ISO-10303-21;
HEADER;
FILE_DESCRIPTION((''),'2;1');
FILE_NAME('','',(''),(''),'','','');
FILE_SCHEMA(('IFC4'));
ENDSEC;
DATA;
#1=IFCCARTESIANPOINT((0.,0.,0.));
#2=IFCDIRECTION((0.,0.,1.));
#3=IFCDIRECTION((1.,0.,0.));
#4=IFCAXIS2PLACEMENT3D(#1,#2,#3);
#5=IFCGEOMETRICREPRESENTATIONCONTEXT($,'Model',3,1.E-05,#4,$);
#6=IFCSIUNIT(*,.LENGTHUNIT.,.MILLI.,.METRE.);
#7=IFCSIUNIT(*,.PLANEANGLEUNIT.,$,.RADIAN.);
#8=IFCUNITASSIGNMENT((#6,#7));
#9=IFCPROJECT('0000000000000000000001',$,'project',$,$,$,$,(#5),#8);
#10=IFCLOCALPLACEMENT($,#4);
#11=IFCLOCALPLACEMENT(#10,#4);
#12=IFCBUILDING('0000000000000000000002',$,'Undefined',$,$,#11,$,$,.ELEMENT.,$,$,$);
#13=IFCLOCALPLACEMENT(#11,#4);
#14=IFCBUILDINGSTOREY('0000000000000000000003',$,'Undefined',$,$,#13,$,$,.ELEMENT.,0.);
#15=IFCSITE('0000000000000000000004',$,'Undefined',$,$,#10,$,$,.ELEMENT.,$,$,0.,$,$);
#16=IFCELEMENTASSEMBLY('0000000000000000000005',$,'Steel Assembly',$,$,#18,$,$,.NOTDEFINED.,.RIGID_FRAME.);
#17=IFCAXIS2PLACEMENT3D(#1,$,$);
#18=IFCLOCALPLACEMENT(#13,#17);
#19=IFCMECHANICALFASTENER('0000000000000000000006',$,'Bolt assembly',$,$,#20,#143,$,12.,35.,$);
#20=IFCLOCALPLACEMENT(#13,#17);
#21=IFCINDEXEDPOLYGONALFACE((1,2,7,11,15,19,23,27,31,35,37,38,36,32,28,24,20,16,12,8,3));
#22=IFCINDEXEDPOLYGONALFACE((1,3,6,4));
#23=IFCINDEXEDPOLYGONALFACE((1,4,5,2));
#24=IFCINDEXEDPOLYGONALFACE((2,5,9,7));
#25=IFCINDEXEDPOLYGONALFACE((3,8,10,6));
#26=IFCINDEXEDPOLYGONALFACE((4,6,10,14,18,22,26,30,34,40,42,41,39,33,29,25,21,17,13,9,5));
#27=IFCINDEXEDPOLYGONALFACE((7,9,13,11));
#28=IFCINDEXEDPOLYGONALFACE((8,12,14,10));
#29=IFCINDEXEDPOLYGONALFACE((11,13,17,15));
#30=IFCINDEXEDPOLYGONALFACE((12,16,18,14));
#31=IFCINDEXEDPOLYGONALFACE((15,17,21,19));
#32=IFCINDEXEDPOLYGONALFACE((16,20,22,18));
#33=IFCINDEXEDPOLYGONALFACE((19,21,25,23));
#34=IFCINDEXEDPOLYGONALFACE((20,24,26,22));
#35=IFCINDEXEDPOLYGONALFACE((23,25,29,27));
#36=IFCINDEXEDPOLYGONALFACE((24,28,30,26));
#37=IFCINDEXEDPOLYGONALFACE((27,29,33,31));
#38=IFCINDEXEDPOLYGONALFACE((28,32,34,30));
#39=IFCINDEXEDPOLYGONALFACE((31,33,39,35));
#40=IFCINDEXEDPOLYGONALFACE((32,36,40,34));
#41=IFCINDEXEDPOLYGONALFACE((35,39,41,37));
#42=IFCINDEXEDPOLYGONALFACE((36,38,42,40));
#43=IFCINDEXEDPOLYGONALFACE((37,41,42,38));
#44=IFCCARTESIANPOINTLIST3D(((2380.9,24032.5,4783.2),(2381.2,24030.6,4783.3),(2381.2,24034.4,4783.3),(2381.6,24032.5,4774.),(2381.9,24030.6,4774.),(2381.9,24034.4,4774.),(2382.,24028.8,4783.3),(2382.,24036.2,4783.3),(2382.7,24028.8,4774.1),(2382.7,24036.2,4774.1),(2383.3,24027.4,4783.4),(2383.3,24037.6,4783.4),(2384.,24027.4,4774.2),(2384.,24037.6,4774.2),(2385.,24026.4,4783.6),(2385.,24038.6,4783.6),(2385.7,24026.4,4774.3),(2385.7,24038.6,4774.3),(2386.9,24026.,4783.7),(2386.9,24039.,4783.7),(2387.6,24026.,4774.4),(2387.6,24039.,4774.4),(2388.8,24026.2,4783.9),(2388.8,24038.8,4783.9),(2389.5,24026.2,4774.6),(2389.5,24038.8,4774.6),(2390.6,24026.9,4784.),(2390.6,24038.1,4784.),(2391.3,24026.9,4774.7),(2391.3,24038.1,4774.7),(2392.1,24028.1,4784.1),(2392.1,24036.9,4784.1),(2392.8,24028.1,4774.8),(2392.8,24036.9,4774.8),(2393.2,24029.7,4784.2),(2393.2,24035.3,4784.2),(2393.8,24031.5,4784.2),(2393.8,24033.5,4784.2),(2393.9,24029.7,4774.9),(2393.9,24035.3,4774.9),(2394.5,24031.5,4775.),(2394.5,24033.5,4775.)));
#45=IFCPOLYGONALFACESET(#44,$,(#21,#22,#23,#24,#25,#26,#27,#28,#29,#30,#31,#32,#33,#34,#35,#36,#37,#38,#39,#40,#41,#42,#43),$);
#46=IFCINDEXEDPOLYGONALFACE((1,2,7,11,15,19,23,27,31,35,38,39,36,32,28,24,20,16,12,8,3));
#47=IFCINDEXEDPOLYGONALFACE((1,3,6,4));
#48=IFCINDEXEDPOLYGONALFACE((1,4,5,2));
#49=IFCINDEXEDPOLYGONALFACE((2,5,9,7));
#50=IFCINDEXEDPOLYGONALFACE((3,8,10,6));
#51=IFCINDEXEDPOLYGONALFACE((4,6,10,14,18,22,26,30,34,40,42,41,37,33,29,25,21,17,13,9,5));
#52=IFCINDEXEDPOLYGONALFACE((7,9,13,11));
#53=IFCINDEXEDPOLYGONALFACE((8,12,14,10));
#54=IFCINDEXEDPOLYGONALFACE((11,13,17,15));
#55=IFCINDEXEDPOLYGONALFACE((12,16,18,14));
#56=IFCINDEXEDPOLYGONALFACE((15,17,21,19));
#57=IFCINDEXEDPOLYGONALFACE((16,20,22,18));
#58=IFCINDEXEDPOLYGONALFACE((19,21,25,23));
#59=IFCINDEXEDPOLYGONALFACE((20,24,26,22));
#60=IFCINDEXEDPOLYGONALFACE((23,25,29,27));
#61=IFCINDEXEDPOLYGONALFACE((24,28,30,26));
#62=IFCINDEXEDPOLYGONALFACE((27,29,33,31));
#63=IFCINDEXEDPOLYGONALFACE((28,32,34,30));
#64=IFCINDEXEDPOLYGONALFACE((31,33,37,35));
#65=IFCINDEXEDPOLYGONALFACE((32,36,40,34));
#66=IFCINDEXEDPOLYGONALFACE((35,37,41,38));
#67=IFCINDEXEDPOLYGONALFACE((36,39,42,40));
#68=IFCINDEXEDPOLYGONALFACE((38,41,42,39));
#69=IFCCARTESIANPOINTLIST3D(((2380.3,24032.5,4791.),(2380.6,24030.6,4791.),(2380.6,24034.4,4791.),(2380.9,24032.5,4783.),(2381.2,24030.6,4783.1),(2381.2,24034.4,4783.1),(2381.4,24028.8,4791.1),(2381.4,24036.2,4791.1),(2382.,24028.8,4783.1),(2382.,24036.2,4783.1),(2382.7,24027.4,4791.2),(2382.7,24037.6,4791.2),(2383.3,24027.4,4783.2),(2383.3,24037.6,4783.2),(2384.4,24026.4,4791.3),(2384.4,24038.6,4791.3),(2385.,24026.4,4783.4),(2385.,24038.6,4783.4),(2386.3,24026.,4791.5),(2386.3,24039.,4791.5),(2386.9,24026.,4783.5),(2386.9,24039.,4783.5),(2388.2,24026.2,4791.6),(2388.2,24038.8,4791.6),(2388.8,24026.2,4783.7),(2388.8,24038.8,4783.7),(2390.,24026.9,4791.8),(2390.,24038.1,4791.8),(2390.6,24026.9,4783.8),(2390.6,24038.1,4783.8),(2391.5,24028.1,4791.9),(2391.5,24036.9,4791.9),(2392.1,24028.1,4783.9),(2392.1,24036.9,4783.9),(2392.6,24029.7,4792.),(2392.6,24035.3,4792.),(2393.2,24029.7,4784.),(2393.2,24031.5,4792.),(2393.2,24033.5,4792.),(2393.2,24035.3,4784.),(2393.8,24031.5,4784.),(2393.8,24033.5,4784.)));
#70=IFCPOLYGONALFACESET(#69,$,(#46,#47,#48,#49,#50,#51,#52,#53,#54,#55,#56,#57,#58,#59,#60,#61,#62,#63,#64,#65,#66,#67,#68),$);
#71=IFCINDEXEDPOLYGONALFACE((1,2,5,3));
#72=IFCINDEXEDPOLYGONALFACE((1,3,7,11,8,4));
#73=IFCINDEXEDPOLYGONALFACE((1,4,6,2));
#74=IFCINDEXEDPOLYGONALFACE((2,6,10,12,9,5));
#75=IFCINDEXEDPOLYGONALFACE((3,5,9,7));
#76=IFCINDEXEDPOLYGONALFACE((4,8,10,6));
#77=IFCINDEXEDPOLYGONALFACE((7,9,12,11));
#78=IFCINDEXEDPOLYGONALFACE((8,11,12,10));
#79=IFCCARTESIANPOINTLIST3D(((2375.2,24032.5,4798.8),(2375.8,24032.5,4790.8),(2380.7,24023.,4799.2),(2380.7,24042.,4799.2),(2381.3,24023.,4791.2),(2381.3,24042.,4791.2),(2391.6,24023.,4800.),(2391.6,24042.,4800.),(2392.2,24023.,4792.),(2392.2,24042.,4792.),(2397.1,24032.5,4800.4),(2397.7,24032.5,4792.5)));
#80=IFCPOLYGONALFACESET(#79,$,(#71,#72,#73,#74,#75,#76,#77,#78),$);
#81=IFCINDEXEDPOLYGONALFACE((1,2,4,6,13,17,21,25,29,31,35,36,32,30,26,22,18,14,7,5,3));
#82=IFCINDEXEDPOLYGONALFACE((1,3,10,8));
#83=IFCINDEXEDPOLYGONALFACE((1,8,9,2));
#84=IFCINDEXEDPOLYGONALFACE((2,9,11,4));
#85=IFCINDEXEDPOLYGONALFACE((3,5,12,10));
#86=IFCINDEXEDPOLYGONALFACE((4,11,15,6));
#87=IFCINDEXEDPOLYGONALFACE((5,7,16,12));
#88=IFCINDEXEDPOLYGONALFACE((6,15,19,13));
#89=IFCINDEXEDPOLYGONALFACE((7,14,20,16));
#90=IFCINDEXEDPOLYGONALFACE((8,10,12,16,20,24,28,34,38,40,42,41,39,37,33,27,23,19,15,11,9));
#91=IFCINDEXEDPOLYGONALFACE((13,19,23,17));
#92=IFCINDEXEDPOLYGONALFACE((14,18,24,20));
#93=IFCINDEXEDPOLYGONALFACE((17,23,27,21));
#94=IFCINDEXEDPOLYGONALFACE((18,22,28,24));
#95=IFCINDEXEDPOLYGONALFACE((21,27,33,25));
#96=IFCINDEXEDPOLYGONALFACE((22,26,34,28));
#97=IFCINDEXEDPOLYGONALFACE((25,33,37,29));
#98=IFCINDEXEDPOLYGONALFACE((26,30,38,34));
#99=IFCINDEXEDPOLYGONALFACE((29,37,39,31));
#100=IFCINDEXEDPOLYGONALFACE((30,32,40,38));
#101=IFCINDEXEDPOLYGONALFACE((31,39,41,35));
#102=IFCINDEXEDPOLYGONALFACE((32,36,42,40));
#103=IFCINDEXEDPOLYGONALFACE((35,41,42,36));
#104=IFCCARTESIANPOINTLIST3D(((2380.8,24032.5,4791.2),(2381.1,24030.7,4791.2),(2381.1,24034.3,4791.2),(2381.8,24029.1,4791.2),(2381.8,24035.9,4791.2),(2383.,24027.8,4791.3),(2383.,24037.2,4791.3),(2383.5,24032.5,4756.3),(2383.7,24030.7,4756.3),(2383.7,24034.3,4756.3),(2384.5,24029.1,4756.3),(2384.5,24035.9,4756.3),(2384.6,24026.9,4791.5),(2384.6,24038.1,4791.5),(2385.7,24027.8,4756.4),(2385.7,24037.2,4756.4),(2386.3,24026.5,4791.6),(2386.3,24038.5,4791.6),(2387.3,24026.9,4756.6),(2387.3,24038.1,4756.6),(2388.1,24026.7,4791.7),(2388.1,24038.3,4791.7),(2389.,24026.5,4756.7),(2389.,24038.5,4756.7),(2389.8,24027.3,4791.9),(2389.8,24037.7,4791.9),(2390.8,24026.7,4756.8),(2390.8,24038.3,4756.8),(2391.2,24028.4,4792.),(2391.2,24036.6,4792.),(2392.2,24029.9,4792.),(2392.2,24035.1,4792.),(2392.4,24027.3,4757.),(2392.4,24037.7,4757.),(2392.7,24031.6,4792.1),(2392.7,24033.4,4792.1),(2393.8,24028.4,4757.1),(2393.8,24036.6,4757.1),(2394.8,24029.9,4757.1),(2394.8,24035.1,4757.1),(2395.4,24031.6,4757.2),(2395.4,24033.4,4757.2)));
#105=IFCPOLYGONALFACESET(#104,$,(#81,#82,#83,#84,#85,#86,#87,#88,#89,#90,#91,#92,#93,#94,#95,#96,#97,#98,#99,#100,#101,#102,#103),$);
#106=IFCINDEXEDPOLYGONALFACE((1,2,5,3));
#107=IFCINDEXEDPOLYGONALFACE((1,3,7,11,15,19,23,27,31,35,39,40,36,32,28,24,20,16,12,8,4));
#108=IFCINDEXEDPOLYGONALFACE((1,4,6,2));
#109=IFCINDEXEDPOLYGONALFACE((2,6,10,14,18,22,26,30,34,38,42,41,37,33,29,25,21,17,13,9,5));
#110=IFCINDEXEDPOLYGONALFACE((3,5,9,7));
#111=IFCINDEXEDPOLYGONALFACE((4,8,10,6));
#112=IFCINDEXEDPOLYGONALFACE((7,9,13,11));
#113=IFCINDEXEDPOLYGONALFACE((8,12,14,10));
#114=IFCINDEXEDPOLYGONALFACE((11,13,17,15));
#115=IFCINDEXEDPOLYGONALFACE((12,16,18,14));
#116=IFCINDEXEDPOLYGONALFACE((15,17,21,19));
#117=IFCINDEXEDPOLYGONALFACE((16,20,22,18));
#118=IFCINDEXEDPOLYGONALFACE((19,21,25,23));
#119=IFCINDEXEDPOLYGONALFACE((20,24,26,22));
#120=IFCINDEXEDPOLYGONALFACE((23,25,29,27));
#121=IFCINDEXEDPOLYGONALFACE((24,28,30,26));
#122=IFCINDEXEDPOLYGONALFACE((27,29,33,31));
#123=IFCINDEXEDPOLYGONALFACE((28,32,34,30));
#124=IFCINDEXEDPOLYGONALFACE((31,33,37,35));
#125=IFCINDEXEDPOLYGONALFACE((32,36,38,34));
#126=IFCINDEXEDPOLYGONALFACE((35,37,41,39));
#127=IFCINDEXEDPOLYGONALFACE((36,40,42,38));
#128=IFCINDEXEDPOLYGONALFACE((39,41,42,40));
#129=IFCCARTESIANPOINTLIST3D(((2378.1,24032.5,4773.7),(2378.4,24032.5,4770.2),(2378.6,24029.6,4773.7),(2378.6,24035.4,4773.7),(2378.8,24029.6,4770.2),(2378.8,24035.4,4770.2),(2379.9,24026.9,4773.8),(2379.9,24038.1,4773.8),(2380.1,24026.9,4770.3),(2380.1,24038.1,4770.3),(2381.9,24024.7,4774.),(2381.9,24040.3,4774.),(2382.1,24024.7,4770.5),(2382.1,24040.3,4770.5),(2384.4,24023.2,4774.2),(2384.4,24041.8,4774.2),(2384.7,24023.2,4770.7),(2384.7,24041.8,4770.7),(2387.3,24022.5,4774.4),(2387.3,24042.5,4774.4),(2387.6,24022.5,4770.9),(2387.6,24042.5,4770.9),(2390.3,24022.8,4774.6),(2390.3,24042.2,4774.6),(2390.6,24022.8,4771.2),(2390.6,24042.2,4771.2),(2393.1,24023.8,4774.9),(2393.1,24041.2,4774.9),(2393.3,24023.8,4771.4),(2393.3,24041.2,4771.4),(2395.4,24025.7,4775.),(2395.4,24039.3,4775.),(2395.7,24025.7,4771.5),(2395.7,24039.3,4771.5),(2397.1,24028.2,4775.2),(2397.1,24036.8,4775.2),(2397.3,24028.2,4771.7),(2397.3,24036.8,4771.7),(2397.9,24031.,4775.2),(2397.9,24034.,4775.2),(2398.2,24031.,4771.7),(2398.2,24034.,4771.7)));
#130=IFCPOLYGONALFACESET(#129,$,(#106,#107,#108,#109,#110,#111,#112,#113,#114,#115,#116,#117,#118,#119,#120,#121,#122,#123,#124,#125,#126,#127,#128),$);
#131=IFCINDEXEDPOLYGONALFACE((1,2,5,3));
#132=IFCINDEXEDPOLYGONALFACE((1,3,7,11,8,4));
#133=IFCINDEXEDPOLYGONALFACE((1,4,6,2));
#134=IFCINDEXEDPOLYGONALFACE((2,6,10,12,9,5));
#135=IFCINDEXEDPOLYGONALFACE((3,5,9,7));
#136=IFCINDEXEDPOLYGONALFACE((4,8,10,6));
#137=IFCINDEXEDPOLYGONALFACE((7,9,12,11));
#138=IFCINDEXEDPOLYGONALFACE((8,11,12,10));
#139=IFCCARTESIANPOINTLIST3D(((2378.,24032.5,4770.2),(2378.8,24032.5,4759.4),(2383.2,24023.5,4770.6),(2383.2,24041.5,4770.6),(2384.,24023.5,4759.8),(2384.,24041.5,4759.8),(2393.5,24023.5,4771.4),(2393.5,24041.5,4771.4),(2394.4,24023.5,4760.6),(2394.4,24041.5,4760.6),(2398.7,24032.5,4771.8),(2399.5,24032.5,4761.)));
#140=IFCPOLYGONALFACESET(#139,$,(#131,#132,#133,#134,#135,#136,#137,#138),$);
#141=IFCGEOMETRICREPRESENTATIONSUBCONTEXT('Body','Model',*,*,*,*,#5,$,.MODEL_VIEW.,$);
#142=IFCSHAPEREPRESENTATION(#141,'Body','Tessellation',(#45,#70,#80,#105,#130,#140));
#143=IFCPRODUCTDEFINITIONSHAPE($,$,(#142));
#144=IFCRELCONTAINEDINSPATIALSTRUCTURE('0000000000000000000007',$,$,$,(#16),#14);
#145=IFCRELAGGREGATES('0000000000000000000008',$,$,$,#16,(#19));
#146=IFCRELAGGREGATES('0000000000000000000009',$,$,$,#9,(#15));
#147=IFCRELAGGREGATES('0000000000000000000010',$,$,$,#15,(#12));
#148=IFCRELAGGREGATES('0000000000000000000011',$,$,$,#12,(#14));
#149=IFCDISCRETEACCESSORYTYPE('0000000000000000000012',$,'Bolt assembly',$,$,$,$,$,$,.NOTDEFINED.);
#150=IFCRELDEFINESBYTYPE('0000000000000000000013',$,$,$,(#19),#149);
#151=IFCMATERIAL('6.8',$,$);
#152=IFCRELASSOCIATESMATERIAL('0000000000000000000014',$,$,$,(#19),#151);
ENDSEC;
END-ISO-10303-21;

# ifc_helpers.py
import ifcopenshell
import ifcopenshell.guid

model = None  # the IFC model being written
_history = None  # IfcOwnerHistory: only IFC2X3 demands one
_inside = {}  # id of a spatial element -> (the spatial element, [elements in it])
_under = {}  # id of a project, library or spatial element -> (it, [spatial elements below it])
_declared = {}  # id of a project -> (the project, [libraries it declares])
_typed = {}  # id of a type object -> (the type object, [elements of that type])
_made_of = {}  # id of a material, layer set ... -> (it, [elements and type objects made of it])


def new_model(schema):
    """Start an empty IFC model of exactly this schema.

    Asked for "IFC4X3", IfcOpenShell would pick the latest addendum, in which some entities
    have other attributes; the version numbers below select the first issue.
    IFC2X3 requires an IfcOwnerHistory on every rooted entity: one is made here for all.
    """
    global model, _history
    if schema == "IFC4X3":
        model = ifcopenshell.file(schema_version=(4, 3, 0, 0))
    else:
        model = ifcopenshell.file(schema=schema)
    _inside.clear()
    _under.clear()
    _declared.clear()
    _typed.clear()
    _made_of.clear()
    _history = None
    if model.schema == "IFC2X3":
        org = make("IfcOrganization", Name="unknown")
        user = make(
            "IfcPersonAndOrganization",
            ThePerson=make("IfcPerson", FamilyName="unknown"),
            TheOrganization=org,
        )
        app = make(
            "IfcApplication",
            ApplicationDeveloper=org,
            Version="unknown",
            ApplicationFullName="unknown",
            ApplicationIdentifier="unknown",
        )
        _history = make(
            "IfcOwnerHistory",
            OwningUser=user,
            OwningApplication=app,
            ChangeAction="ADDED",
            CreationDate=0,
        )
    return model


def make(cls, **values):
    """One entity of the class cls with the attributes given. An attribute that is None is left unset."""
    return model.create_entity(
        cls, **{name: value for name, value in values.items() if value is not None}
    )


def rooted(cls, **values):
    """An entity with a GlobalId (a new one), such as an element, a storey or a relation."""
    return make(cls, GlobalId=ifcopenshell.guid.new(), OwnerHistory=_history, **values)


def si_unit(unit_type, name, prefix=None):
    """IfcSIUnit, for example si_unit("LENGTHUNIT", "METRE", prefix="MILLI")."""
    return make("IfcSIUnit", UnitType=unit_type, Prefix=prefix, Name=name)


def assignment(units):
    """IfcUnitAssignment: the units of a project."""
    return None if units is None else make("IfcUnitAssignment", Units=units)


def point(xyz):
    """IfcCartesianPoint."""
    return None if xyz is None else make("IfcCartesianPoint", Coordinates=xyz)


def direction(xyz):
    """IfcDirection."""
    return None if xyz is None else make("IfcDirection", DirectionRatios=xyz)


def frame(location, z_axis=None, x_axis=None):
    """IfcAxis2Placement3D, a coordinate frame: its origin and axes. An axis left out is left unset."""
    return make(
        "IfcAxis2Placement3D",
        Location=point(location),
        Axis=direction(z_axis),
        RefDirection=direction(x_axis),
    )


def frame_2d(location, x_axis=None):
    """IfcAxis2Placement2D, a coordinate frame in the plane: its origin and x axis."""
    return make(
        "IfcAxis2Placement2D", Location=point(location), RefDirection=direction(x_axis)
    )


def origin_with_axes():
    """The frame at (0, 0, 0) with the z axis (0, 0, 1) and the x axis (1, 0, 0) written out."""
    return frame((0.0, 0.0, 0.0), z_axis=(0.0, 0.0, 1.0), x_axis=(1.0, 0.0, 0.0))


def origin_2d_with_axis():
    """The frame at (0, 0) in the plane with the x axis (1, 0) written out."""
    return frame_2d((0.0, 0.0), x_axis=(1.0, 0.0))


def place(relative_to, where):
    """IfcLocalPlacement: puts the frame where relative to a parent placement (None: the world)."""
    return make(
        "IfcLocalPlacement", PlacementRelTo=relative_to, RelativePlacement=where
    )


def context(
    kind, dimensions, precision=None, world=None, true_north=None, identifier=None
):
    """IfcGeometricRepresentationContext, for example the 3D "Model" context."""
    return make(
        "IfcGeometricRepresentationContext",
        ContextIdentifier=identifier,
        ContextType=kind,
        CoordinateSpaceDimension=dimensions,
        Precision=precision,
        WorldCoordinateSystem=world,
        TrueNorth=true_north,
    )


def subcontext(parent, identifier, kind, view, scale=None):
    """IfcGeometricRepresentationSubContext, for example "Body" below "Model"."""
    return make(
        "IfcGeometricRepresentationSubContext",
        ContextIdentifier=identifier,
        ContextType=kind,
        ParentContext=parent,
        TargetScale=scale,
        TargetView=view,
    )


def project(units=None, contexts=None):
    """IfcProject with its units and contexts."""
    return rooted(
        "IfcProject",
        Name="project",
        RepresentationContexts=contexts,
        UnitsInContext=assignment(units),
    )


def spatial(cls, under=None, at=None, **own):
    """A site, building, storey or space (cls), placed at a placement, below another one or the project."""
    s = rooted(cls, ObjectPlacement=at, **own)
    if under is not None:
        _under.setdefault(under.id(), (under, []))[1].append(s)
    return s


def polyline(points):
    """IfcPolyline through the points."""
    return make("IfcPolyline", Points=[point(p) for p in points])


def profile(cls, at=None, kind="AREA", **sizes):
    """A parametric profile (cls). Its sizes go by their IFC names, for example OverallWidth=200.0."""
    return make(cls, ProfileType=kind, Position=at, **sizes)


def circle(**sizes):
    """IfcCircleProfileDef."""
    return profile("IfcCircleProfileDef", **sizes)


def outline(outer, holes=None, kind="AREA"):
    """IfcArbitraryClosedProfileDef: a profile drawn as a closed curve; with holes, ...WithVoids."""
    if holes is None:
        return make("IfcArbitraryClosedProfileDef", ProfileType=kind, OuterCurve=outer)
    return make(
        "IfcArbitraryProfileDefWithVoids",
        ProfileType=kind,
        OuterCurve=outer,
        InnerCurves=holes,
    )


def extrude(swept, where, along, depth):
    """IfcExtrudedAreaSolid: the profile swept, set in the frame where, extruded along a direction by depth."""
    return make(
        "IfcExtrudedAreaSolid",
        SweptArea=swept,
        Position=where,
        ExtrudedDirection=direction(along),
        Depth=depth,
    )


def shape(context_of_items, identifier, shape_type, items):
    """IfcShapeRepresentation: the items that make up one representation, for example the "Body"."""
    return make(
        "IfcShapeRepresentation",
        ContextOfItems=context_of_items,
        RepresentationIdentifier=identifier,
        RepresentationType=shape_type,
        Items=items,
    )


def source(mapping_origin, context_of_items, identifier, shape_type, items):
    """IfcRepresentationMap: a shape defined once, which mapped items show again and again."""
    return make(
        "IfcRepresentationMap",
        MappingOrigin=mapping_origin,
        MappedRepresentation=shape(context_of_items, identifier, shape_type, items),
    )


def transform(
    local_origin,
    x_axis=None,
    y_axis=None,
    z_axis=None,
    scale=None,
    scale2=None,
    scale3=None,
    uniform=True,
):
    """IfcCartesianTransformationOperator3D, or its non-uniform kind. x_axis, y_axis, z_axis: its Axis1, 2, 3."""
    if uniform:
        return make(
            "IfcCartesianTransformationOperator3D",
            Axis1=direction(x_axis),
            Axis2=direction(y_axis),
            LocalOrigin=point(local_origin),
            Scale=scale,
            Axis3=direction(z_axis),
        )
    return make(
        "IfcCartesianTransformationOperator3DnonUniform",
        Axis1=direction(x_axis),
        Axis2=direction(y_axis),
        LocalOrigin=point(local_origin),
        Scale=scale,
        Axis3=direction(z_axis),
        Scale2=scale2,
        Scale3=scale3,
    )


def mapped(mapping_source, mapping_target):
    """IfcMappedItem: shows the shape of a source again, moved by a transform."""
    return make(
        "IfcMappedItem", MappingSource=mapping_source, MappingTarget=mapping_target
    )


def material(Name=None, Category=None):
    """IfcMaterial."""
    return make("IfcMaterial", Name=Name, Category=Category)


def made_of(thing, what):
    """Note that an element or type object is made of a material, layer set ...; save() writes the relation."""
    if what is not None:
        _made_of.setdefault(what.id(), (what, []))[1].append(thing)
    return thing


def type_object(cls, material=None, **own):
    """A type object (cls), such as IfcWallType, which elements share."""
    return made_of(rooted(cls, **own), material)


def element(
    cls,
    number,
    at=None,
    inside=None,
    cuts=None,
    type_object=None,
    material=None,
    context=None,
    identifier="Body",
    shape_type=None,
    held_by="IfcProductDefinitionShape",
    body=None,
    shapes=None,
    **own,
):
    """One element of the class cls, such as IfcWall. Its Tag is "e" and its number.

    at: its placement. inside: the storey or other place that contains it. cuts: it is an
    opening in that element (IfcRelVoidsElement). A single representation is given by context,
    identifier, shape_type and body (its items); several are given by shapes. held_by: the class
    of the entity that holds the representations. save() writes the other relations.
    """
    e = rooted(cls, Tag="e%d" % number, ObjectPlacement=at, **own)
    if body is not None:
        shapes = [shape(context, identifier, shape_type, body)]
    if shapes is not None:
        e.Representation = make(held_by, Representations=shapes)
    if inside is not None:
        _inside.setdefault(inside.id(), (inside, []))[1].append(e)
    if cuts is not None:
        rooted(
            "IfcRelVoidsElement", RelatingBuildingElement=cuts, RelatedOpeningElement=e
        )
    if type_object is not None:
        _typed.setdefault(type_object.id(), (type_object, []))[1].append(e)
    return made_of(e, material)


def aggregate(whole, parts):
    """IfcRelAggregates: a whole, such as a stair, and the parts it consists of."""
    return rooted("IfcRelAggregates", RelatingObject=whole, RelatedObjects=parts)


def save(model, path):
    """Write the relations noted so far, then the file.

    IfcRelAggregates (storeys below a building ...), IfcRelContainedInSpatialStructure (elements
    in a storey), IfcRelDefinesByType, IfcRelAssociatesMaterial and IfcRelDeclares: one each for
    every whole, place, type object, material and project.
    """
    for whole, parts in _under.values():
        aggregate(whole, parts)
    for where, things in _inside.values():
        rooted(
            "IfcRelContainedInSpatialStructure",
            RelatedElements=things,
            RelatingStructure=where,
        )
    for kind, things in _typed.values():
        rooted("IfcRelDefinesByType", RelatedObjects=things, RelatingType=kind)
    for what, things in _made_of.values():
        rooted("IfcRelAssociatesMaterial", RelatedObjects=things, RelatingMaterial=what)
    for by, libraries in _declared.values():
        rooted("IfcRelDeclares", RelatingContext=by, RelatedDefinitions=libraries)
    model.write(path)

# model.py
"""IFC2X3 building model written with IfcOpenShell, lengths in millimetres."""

from ifc_helpers import new_model, si_unit, frame, origin_with_axes, origin_2d_with_axis, place, context, subcontext, project, spatial, polyline, circle, outline, extrude, source, transform, mapped, material, type_object, element, aggregate, save


model = new_model("IFC2X3")

# Units and contexts
model_context = context("Model", 3, precision=1e-05, world=origin_with_axes())
body_context = subcontext(model_context, "Body", "Model", "MODEL_VIEW")
ifc_project = project(units=[si_unit("LENGTHUNIT", "METRE", prefix="MILLI"), si_unit("PLANEANGLEUNIT", "RADIAN")], contexts=[model_context])

# Site, building, storey
site_placement = place(None, origin_with_axes())
site = spatial("IfcSite", under=ifc_project, at=site_placement, Name="Undefined", CompositionType="ELEMENT", RefElevation=0.0)
building_placement = place(site_placement, origin_with_axes())
building = spatial("IfcBuilding", under=site, at=building_placement, Name="Undefined", CompositionType="ELEMENT")
storey_placement = place(building_placement, origin_with_axes())
storey = spatial("IfcBuildingStorey", under=building, at=storey_placement, Name="Undefined", CompositionType="ELEMENT", Elevation=0.0)

# Shared definitions
ifc_material_1 = material(Name="6.8")
discrete_accessory_type_1 = type_object("IfcDiscreteAccessoryType", Name="Bolt assembly")

# Element assembly, mechanical fastener
shared_shape_1 = source(origin_with_axes(), body_context, "Body", "SweptSolid", [
    extrude(circle(Radius=6.5, at=origin_2d_with_axis()), frame((0.0, -0.1, 0.0), z_axis=(0.0, 1.0, 0.0), x_axis=(1.0, 0.0, 0.0)), (0.0, 0.0, 1.0), 9.3),
    extrude(circle(Radius=6.5, at=origin_2d_with_axis()), frame((0.0, -7.9, 0.0), z_axis=(0.0, 1.0, 0.0), x_axis=(1.0, 0.0, 0.0)), (0.0, 0.0, 1.0), 8.0),
    extrude(outline(polyline([(11.0, 0.0), (5.5, 9.5), (-5.5, 9.5), (-11.0, 0.0), (-5.5, -9.5), (5.5, -9.5), (11.0, 0.0)])), frame((0.0, -16.0, 0.0), z_axis=(0.0, 1.0, 0.0), x_axis=(1.0, 0.0, 0.0)), (0.0, 0.0, 1.0), 8.0),
    extrude(circle(Radius=6.0, at=origin_2d_with_axis()), frame((0.0, -8.0, 0.0), z_axis=(0.0, 1.0, 0.0), x_axis=(1.0, 0.0, 0.0)), (0.0, 0.0, 1.0), 35.0),
    extrude(circle(Radius=10.0, at=origin_2d_with_axis()), frame((0.0, 9.2, 0.0), z_axis=(0.0, 1.0, 0.0), x_axis=(1.0, 0.0, 0.0)), (0.0, 0.0, 1.0), 3.5),
    extrude(outline(polyline([(10.4, 0.0), (5.2, 9.0), (-5.2, 9.0), (-10.4, 0.0), (-5.2, -9.0), (5.2, -9.0), (10.4, 0.0)])), frame((0.0, 12.7, 0.0), z_axis=(0.0, 1.0, 0.0), x_axis=(1.0, 0.0, 0.0)), (0.0, 0.0, 1.0), 10.8),
])
assembly_1_placement = place(storey_placement, origin_with_axes())
assembly_1 = element("IfcElementAssembly", 1, at=assembly_1_placement, inside=storey, Name="Steel Assembly", AssemblyPlace="NOTDEFINED", PredefinedType="RIGID_FRAME")
mechanical_fastener_1_placement = place(assembly_1_placement, frame((2387.4, 24032.5, 4783.6), z_axis=(0.0, -1.0, 0.0), x_axis=(-0.997054, 0.0, -0.076696)))
mechanical_fastener_1 = element("IfcMechanicalFastener", 2, at=mechanical_fastener_1_placement, type_object=discrete_accessory_type_1, material=ifc_material_1, Name="Bolt assembly", NominalDiameter=12.0, NominalLength=35.0, context=body_context, shape_type="MappedRepresentation", body=[
    mapped(shared_shape_1, transform((0.0, 0.0, 0.0))),
])
aggregate(assembly_1, [mechanical_fastener_1])

save(model, "model.ifc")
